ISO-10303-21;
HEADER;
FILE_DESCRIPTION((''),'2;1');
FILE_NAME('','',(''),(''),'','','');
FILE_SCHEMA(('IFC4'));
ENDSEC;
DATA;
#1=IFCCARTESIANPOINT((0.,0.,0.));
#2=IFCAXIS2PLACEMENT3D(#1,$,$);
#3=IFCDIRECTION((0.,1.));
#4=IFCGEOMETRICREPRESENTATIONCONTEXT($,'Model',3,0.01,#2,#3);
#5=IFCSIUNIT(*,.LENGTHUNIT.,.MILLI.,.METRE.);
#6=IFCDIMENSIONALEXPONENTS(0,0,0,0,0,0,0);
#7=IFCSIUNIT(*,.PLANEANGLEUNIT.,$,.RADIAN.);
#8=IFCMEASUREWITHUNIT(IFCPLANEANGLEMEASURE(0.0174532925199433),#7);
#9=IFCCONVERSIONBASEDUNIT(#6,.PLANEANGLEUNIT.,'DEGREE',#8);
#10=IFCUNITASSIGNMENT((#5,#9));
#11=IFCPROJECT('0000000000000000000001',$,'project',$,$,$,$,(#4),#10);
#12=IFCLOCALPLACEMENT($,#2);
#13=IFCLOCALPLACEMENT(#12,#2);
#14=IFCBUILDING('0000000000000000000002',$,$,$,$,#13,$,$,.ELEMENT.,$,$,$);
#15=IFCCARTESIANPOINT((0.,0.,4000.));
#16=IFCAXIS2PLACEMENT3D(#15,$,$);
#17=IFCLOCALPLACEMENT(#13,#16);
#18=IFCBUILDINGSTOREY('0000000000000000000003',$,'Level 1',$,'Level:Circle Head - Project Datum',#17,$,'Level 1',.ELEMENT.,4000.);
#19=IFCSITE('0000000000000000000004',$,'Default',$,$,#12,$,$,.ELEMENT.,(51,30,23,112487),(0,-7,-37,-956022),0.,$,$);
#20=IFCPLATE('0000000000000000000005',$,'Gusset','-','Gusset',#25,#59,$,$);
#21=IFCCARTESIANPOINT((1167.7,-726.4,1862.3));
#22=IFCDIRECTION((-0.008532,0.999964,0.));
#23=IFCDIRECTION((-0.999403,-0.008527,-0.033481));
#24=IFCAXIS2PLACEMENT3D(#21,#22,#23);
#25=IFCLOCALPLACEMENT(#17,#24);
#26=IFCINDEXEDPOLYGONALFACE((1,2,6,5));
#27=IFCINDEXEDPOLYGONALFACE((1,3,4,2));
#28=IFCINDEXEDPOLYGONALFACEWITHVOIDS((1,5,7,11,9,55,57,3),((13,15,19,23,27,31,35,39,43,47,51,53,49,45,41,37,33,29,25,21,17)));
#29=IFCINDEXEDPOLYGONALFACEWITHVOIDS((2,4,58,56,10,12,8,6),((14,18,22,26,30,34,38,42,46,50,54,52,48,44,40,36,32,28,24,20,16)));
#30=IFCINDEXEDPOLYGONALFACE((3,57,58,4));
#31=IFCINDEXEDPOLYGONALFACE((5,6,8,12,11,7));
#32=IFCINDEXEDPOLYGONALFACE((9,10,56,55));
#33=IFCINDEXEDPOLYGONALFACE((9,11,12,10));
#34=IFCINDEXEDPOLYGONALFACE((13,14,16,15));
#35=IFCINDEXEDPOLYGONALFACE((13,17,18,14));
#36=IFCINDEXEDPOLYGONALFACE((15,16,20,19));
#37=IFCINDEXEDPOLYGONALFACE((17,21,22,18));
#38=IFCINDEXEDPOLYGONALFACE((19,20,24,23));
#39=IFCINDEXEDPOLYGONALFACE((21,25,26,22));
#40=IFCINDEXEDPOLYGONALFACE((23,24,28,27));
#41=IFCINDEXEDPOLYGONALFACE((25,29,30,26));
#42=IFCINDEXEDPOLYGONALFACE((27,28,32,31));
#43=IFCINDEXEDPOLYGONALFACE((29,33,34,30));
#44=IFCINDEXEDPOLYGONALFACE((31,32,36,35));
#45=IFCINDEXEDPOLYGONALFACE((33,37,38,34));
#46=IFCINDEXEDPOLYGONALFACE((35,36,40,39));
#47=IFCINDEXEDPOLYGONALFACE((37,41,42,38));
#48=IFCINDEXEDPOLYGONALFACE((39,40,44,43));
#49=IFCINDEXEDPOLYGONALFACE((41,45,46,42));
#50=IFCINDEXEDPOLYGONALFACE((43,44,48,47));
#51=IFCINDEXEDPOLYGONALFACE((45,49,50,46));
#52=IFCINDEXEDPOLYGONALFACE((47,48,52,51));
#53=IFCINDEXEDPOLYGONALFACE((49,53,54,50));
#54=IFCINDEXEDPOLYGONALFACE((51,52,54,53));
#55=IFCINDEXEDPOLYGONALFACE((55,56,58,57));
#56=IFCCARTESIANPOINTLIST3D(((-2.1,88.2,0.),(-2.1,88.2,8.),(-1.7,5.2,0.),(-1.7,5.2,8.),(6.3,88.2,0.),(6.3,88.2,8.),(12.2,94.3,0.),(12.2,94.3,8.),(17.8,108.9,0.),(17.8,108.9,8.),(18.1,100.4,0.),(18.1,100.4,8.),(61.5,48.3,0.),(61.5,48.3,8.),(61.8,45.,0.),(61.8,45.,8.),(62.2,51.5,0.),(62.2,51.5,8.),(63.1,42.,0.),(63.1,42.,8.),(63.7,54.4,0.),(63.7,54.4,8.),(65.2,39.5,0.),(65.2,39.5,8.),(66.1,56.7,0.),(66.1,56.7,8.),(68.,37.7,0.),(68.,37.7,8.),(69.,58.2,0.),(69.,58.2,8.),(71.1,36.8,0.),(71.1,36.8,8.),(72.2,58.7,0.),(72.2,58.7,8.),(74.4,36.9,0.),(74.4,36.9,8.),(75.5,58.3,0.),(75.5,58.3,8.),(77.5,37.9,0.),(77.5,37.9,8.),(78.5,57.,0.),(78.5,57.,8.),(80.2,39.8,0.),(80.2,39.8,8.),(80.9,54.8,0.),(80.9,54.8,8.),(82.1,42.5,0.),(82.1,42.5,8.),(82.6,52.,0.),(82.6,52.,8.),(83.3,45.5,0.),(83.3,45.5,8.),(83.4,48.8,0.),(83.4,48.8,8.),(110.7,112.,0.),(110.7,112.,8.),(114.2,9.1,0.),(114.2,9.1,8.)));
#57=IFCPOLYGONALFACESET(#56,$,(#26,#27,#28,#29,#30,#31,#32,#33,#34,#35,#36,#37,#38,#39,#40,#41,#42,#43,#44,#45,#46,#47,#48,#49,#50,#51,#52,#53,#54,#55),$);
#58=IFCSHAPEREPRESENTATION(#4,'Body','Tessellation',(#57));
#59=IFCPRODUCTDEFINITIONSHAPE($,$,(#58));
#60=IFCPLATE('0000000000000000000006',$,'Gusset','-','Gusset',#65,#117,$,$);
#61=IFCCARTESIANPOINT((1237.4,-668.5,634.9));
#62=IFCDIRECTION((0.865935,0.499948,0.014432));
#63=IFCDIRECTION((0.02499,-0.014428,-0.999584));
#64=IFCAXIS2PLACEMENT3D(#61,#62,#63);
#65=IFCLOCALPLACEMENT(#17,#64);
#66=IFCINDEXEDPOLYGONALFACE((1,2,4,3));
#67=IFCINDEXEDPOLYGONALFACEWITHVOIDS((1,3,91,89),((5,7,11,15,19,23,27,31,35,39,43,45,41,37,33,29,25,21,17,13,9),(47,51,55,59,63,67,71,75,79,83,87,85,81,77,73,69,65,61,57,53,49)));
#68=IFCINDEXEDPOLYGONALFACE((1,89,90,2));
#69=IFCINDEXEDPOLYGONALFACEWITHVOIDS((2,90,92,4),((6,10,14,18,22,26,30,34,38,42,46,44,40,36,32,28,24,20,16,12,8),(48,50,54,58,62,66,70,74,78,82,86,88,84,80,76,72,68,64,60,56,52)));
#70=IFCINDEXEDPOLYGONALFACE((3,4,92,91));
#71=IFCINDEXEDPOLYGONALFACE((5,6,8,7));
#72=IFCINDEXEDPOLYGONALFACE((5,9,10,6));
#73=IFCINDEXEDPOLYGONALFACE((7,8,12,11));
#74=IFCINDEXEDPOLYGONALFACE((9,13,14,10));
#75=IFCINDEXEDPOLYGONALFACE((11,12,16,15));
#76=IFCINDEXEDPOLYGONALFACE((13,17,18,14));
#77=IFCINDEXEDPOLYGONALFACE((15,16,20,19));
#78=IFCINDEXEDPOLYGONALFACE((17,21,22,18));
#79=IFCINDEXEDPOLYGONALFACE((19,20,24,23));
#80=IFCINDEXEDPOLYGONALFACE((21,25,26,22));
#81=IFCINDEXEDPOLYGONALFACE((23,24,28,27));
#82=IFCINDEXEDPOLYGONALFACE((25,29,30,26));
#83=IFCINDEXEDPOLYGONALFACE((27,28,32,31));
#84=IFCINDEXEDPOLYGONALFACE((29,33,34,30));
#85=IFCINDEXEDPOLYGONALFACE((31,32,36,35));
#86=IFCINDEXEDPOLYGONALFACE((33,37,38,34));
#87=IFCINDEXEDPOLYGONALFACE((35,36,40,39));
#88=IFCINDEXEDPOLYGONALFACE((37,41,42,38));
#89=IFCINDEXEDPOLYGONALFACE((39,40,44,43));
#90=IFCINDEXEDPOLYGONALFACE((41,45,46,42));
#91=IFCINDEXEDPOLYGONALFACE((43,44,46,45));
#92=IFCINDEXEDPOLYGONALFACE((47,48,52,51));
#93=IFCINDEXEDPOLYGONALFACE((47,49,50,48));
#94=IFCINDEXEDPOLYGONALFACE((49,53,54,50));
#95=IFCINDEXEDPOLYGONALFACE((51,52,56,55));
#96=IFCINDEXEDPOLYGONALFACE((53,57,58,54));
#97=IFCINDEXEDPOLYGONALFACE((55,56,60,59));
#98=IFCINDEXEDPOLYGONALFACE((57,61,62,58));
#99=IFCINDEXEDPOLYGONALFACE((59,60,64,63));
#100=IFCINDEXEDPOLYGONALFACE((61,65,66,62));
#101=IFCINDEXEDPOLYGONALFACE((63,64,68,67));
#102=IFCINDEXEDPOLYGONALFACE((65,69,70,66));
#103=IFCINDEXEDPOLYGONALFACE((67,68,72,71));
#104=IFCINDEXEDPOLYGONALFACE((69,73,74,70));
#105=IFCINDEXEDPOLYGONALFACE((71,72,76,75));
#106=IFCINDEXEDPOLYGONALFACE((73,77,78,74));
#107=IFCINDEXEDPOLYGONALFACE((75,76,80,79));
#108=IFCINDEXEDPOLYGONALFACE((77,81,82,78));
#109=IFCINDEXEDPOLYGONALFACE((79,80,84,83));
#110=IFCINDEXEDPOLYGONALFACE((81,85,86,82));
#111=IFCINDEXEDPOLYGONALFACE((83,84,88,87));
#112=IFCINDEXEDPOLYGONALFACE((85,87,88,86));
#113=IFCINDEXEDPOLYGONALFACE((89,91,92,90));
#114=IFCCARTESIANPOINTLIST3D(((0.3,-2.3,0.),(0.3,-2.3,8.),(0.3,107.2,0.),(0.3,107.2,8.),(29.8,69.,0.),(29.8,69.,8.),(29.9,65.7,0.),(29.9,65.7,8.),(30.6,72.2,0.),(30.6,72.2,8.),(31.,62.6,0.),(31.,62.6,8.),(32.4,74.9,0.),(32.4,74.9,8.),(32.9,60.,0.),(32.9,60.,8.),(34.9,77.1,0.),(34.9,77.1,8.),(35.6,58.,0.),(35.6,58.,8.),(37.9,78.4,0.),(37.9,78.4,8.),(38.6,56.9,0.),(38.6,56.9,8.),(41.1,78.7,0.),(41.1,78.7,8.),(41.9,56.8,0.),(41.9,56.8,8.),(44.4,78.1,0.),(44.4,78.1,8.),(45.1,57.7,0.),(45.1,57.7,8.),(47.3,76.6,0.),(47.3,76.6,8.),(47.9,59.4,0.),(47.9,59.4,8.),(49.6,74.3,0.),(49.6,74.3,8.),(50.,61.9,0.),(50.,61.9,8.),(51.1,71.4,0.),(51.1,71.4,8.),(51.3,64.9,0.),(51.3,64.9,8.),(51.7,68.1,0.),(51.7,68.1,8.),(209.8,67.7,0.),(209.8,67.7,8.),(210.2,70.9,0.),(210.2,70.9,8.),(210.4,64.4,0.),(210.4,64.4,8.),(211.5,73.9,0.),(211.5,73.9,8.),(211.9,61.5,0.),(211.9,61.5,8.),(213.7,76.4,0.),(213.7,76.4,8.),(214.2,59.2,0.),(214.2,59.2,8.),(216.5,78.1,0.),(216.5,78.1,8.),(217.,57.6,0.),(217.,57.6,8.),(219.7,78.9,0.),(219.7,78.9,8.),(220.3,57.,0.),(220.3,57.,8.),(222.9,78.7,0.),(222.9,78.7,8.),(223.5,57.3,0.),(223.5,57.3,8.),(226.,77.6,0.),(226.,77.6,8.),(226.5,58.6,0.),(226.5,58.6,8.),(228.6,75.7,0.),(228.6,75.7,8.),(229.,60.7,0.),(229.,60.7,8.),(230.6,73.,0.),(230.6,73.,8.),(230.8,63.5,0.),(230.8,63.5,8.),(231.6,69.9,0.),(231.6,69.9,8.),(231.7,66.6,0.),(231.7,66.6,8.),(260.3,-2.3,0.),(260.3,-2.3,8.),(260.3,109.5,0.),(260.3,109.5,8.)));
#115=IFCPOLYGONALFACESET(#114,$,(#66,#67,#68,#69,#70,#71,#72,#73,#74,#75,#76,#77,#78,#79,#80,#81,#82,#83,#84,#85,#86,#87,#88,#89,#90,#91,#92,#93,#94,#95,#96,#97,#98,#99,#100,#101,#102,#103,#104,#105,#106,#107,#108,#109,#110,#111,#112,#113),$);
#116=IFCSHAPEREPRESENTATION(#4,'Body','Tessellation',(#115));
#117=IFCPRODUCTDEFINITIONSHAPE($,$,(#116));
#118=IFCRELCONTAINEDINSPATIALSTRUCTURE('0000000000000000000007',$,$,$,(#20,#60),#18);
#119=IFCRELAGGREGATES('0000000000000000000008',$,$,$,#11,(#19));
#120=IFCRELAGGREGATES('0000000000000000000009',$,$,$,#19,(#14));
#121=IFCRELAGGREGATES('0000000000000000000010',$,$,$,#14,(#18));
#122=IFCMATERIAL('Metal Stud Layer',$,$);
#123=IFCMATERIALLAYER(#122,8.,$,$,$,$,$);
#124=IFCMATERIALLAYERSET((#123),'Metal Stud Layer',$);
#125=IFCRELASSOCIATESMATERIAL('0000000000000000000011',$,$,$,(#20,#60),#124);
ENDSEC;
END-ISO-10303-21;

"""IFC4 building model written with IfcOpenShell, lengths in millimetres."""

from ifc_helpers import new_model, entity, si_unit, converted_unit, point, direction, frame, frame_2d, origin, origin_with_axes, origin_2d_with_axis, place, context, project, spatial, polyline, circle_curve, line_curve, trimmed, segment, composite_curve, circle, outline, extrude, material, layer, layer_set, element, save


model = new_model("IFC4")

# Units and contexts
model_context = context("Model", 3, precision=0.01, world=origin(), true_north=direction((0.0, 1.0)))
ifc_project = project(units=[si_unit("LENGTHUNIT", "METRE", prefix="MILLI"), converted_unit("PLANEANGLEUNIT", "DEGREE", entity("IfcPlaneAngleMeasure", 0.0174532925199433), si_unit("PLANEANGLEUNIT", "RADIAN"), dimensions=[0, 0, 0, 0, 0, 0, 0])], contexts=[model_context])

# Site, building, storey
site_placement = place(None, origin())
site = spatial("IfcSite", under=ifc_project, at=site_placement, Name="Default", CompositionType="ELEMENT", RefLatitude=(51, 30, 23, 112487), RefLongitude=(0, -7, -37, -956022), RefElevation=0.0)
building_placement = place(site_placement, origin())
building = spatial("IfcBuilding", under=site, at=building_placement, CompositionType="ELEMENT")
storey_placement = place(building_placement, frame((0.0, 0.0, 4000.0)))
storey = spatial("IfcBuildingStorey", under=building, at=storey_placement, Name="Level 1", ObjectType="Level:Circle Head - Project Datum", LongName="Level 1", CompositionType="ELEMENT", Elevation=4000.0)

# Plate, openings
ifc_material_1 = material(Name="Metal Stud Layer")
ifc_layer_1 = layer(ifc_material_1, 8.0)
ifc_layer_set_1 = layer_set([ifc_layer_1], Name="Metal Stud Layer")
plate_1_placement = place(storey_placement, frame((1167.7, -726.4, 1862.3), z_axis=(-0.008532, 0.999964, 0.0), x_axis=(-0.999403, -0.008527, -0.033481)))
plate_1 = element("IfcPlate", 1, at=plate_1_placement, inside=storey, material=ifc_layer_set_1, Name="Gusset", Description="-", ObjectType="Gusset", context=model_context, shape_type="SweptSolid", body=[
    extrude(outline(polyline([(18.1, 100.4), (6.3, 88.2), (-2.1, 88.2), (-1.7, 5.2), (114.2, 9.1), (110.7, 112.0), (17.8, 108.9), (18.1, 100.4)])), origin_with_axes(), (0.0, 0.0, 1.0), 8.0),
])
opening_1_placement = place(plate_1_placement, origin_with_axes())
element("IfcOpeningElement", 2, at=opening_1_placement, cuts=plate_1, ObjectType="Opening", context=model_context, shape_type="SweptSolid", body=[
    extrude(outline(composite_curve([segment(trimmed(line_curve((18.1, 100.4), (-0.693597, -0.720363), 8.455359), [point((18.1, 100.4))], [point((12.2, 94.3))], True, "CARTESIAN"), True, "CONTINUOUS"), segment(trimmed(circle_curve(frame_2d((-2.2, 108.2), x_axis=(1.0, 0.0)), 20.0), [point((12.2, 94.3))], [point((17.8, 108.9))], True, "CARTESIAN"), True, "CONTINUOUS"), segment(trimmed(line_curve((17.8, 108.9), (0.033481, -0.999439), 8.455359), [point((17.8, 108.9))], [point((18.1, 100.4))], True, "CARTESIAN"), True, "CONTINUOUS")], self_intersect="UNKNOWN")), origin(), (0.0, 0.0, 1.0), 8.0),
])
opening_2_placement = place(plate_1_placement, origin_with_axes())
element("IfcOpeningElement", 3, at=opening_2_placement, cuts=plate_1, ObjectType="Opening", context=model_context, shape_type="SweptSolid", body=[
    extrude(outline(composite_curve([segment(trimmed(line_curve((6.3, 88.2), (-0.99999, -0.004369), 8.455359), [point((6.3, 88.2))], [point((-2.1, 88.2))], True, "CARTESIAN"), True, "CONTINUOUS"), segment(trimmed(circle_curve(frame_2d((-2.2, 108.2), x_axis=(1.0, 0.0)), 20.0), [point((-2.1, 88.2))], [point((12.2, 94.3))], True, "CARTESIAN"), True, "CONTINUOUS"), segment(trimmed(line_curve((12.2, 94.3), (-0.693597, -0.720363), 8.455359), [point((12.2, 94.3))], [point((6.3, 88.2))], True, "CARTESIAN"), True, "CONTINUOUS")], self_intersect="UNKNOWN")), origin(), (0.0, 0.0, 1.0), 8.0),
])
opening_3_placement = place(plate_1_placement, frame((72.5, 47.7, -0.5), z_axis=(0.0, 0.0, 1.0), x_axis=(0.877405, -0.479751, 0.0)))
element("IfcOpeningElement", 4, at=opening_3_placement, cuts=plate_1, ObjectType="Opening", context=model_context, shape_type="SweptSolid", body=[
    extrude(circle(Radius=11.0, at=origin_2d_with_axis()), origin(), (0.0, 0.0, 1.0), 9.0),
])

# Plate, openings
plate_2_placement = place(storey_placement, frame((1237.4, -668.5, 634.9), z_axis=(0.865935, 0.499948, 0.014432), x_axis=(0.02499, -0.014428, -0.999584)))
plate_2 = element("IfcPlate", 5, at=plate_2_placement, inside=storey, material=ifc_layer_set_1, Name="Gusset", Description="-", ObjectType="Gusset", context=model_context, shape_type="SweptSolid", body=[
    extrude(outline(polyline([(0.3, -2.3), (260.3, -2.3), (260.3, 109.5), (0.3, 107.2), (0.3, -2.3)])), origin_with_axes(), (0.0, 0.0, 1.0), 8.0),
])
opening_4_placement = place(plate_2_placement, frame((220.8, 68.0, 8.5), z_axis=(0.0, 0.0, -1.0), x_axis=(0.476137, 0.879371, 0.0)))
element("IfcOpeningElement", 6, at=opening_4_placement, cuts=plate_2, ObjectType="Opening", context=model_context, shape_type="SweptSolid", body=[
    extrude(circle(Radius=11.0, at=origin_2d_with_axis()), origin(), (0.0, 0.0, 1.0), 9.0),
])
opening_5_placement = place(plate_2_placement, frame((40.7, 67.8, 8.5), z_axis=(0.0, 0.0, -1.0), x_axis=(-0.530273, 0.847827, 0.0)))
element("IfcOpeningElement", 7, at=opening_5_placement, cuts=plate_2, ObjectType="Opening", context=model_context, shape_type="SweptSolid", body=[
    extrude(circle(Radius=11.0, at=origin_2d_with_axis()), origin(), (0.0, 0.0, 1.0), 9.0),
])

save(model, "model.ifc")
